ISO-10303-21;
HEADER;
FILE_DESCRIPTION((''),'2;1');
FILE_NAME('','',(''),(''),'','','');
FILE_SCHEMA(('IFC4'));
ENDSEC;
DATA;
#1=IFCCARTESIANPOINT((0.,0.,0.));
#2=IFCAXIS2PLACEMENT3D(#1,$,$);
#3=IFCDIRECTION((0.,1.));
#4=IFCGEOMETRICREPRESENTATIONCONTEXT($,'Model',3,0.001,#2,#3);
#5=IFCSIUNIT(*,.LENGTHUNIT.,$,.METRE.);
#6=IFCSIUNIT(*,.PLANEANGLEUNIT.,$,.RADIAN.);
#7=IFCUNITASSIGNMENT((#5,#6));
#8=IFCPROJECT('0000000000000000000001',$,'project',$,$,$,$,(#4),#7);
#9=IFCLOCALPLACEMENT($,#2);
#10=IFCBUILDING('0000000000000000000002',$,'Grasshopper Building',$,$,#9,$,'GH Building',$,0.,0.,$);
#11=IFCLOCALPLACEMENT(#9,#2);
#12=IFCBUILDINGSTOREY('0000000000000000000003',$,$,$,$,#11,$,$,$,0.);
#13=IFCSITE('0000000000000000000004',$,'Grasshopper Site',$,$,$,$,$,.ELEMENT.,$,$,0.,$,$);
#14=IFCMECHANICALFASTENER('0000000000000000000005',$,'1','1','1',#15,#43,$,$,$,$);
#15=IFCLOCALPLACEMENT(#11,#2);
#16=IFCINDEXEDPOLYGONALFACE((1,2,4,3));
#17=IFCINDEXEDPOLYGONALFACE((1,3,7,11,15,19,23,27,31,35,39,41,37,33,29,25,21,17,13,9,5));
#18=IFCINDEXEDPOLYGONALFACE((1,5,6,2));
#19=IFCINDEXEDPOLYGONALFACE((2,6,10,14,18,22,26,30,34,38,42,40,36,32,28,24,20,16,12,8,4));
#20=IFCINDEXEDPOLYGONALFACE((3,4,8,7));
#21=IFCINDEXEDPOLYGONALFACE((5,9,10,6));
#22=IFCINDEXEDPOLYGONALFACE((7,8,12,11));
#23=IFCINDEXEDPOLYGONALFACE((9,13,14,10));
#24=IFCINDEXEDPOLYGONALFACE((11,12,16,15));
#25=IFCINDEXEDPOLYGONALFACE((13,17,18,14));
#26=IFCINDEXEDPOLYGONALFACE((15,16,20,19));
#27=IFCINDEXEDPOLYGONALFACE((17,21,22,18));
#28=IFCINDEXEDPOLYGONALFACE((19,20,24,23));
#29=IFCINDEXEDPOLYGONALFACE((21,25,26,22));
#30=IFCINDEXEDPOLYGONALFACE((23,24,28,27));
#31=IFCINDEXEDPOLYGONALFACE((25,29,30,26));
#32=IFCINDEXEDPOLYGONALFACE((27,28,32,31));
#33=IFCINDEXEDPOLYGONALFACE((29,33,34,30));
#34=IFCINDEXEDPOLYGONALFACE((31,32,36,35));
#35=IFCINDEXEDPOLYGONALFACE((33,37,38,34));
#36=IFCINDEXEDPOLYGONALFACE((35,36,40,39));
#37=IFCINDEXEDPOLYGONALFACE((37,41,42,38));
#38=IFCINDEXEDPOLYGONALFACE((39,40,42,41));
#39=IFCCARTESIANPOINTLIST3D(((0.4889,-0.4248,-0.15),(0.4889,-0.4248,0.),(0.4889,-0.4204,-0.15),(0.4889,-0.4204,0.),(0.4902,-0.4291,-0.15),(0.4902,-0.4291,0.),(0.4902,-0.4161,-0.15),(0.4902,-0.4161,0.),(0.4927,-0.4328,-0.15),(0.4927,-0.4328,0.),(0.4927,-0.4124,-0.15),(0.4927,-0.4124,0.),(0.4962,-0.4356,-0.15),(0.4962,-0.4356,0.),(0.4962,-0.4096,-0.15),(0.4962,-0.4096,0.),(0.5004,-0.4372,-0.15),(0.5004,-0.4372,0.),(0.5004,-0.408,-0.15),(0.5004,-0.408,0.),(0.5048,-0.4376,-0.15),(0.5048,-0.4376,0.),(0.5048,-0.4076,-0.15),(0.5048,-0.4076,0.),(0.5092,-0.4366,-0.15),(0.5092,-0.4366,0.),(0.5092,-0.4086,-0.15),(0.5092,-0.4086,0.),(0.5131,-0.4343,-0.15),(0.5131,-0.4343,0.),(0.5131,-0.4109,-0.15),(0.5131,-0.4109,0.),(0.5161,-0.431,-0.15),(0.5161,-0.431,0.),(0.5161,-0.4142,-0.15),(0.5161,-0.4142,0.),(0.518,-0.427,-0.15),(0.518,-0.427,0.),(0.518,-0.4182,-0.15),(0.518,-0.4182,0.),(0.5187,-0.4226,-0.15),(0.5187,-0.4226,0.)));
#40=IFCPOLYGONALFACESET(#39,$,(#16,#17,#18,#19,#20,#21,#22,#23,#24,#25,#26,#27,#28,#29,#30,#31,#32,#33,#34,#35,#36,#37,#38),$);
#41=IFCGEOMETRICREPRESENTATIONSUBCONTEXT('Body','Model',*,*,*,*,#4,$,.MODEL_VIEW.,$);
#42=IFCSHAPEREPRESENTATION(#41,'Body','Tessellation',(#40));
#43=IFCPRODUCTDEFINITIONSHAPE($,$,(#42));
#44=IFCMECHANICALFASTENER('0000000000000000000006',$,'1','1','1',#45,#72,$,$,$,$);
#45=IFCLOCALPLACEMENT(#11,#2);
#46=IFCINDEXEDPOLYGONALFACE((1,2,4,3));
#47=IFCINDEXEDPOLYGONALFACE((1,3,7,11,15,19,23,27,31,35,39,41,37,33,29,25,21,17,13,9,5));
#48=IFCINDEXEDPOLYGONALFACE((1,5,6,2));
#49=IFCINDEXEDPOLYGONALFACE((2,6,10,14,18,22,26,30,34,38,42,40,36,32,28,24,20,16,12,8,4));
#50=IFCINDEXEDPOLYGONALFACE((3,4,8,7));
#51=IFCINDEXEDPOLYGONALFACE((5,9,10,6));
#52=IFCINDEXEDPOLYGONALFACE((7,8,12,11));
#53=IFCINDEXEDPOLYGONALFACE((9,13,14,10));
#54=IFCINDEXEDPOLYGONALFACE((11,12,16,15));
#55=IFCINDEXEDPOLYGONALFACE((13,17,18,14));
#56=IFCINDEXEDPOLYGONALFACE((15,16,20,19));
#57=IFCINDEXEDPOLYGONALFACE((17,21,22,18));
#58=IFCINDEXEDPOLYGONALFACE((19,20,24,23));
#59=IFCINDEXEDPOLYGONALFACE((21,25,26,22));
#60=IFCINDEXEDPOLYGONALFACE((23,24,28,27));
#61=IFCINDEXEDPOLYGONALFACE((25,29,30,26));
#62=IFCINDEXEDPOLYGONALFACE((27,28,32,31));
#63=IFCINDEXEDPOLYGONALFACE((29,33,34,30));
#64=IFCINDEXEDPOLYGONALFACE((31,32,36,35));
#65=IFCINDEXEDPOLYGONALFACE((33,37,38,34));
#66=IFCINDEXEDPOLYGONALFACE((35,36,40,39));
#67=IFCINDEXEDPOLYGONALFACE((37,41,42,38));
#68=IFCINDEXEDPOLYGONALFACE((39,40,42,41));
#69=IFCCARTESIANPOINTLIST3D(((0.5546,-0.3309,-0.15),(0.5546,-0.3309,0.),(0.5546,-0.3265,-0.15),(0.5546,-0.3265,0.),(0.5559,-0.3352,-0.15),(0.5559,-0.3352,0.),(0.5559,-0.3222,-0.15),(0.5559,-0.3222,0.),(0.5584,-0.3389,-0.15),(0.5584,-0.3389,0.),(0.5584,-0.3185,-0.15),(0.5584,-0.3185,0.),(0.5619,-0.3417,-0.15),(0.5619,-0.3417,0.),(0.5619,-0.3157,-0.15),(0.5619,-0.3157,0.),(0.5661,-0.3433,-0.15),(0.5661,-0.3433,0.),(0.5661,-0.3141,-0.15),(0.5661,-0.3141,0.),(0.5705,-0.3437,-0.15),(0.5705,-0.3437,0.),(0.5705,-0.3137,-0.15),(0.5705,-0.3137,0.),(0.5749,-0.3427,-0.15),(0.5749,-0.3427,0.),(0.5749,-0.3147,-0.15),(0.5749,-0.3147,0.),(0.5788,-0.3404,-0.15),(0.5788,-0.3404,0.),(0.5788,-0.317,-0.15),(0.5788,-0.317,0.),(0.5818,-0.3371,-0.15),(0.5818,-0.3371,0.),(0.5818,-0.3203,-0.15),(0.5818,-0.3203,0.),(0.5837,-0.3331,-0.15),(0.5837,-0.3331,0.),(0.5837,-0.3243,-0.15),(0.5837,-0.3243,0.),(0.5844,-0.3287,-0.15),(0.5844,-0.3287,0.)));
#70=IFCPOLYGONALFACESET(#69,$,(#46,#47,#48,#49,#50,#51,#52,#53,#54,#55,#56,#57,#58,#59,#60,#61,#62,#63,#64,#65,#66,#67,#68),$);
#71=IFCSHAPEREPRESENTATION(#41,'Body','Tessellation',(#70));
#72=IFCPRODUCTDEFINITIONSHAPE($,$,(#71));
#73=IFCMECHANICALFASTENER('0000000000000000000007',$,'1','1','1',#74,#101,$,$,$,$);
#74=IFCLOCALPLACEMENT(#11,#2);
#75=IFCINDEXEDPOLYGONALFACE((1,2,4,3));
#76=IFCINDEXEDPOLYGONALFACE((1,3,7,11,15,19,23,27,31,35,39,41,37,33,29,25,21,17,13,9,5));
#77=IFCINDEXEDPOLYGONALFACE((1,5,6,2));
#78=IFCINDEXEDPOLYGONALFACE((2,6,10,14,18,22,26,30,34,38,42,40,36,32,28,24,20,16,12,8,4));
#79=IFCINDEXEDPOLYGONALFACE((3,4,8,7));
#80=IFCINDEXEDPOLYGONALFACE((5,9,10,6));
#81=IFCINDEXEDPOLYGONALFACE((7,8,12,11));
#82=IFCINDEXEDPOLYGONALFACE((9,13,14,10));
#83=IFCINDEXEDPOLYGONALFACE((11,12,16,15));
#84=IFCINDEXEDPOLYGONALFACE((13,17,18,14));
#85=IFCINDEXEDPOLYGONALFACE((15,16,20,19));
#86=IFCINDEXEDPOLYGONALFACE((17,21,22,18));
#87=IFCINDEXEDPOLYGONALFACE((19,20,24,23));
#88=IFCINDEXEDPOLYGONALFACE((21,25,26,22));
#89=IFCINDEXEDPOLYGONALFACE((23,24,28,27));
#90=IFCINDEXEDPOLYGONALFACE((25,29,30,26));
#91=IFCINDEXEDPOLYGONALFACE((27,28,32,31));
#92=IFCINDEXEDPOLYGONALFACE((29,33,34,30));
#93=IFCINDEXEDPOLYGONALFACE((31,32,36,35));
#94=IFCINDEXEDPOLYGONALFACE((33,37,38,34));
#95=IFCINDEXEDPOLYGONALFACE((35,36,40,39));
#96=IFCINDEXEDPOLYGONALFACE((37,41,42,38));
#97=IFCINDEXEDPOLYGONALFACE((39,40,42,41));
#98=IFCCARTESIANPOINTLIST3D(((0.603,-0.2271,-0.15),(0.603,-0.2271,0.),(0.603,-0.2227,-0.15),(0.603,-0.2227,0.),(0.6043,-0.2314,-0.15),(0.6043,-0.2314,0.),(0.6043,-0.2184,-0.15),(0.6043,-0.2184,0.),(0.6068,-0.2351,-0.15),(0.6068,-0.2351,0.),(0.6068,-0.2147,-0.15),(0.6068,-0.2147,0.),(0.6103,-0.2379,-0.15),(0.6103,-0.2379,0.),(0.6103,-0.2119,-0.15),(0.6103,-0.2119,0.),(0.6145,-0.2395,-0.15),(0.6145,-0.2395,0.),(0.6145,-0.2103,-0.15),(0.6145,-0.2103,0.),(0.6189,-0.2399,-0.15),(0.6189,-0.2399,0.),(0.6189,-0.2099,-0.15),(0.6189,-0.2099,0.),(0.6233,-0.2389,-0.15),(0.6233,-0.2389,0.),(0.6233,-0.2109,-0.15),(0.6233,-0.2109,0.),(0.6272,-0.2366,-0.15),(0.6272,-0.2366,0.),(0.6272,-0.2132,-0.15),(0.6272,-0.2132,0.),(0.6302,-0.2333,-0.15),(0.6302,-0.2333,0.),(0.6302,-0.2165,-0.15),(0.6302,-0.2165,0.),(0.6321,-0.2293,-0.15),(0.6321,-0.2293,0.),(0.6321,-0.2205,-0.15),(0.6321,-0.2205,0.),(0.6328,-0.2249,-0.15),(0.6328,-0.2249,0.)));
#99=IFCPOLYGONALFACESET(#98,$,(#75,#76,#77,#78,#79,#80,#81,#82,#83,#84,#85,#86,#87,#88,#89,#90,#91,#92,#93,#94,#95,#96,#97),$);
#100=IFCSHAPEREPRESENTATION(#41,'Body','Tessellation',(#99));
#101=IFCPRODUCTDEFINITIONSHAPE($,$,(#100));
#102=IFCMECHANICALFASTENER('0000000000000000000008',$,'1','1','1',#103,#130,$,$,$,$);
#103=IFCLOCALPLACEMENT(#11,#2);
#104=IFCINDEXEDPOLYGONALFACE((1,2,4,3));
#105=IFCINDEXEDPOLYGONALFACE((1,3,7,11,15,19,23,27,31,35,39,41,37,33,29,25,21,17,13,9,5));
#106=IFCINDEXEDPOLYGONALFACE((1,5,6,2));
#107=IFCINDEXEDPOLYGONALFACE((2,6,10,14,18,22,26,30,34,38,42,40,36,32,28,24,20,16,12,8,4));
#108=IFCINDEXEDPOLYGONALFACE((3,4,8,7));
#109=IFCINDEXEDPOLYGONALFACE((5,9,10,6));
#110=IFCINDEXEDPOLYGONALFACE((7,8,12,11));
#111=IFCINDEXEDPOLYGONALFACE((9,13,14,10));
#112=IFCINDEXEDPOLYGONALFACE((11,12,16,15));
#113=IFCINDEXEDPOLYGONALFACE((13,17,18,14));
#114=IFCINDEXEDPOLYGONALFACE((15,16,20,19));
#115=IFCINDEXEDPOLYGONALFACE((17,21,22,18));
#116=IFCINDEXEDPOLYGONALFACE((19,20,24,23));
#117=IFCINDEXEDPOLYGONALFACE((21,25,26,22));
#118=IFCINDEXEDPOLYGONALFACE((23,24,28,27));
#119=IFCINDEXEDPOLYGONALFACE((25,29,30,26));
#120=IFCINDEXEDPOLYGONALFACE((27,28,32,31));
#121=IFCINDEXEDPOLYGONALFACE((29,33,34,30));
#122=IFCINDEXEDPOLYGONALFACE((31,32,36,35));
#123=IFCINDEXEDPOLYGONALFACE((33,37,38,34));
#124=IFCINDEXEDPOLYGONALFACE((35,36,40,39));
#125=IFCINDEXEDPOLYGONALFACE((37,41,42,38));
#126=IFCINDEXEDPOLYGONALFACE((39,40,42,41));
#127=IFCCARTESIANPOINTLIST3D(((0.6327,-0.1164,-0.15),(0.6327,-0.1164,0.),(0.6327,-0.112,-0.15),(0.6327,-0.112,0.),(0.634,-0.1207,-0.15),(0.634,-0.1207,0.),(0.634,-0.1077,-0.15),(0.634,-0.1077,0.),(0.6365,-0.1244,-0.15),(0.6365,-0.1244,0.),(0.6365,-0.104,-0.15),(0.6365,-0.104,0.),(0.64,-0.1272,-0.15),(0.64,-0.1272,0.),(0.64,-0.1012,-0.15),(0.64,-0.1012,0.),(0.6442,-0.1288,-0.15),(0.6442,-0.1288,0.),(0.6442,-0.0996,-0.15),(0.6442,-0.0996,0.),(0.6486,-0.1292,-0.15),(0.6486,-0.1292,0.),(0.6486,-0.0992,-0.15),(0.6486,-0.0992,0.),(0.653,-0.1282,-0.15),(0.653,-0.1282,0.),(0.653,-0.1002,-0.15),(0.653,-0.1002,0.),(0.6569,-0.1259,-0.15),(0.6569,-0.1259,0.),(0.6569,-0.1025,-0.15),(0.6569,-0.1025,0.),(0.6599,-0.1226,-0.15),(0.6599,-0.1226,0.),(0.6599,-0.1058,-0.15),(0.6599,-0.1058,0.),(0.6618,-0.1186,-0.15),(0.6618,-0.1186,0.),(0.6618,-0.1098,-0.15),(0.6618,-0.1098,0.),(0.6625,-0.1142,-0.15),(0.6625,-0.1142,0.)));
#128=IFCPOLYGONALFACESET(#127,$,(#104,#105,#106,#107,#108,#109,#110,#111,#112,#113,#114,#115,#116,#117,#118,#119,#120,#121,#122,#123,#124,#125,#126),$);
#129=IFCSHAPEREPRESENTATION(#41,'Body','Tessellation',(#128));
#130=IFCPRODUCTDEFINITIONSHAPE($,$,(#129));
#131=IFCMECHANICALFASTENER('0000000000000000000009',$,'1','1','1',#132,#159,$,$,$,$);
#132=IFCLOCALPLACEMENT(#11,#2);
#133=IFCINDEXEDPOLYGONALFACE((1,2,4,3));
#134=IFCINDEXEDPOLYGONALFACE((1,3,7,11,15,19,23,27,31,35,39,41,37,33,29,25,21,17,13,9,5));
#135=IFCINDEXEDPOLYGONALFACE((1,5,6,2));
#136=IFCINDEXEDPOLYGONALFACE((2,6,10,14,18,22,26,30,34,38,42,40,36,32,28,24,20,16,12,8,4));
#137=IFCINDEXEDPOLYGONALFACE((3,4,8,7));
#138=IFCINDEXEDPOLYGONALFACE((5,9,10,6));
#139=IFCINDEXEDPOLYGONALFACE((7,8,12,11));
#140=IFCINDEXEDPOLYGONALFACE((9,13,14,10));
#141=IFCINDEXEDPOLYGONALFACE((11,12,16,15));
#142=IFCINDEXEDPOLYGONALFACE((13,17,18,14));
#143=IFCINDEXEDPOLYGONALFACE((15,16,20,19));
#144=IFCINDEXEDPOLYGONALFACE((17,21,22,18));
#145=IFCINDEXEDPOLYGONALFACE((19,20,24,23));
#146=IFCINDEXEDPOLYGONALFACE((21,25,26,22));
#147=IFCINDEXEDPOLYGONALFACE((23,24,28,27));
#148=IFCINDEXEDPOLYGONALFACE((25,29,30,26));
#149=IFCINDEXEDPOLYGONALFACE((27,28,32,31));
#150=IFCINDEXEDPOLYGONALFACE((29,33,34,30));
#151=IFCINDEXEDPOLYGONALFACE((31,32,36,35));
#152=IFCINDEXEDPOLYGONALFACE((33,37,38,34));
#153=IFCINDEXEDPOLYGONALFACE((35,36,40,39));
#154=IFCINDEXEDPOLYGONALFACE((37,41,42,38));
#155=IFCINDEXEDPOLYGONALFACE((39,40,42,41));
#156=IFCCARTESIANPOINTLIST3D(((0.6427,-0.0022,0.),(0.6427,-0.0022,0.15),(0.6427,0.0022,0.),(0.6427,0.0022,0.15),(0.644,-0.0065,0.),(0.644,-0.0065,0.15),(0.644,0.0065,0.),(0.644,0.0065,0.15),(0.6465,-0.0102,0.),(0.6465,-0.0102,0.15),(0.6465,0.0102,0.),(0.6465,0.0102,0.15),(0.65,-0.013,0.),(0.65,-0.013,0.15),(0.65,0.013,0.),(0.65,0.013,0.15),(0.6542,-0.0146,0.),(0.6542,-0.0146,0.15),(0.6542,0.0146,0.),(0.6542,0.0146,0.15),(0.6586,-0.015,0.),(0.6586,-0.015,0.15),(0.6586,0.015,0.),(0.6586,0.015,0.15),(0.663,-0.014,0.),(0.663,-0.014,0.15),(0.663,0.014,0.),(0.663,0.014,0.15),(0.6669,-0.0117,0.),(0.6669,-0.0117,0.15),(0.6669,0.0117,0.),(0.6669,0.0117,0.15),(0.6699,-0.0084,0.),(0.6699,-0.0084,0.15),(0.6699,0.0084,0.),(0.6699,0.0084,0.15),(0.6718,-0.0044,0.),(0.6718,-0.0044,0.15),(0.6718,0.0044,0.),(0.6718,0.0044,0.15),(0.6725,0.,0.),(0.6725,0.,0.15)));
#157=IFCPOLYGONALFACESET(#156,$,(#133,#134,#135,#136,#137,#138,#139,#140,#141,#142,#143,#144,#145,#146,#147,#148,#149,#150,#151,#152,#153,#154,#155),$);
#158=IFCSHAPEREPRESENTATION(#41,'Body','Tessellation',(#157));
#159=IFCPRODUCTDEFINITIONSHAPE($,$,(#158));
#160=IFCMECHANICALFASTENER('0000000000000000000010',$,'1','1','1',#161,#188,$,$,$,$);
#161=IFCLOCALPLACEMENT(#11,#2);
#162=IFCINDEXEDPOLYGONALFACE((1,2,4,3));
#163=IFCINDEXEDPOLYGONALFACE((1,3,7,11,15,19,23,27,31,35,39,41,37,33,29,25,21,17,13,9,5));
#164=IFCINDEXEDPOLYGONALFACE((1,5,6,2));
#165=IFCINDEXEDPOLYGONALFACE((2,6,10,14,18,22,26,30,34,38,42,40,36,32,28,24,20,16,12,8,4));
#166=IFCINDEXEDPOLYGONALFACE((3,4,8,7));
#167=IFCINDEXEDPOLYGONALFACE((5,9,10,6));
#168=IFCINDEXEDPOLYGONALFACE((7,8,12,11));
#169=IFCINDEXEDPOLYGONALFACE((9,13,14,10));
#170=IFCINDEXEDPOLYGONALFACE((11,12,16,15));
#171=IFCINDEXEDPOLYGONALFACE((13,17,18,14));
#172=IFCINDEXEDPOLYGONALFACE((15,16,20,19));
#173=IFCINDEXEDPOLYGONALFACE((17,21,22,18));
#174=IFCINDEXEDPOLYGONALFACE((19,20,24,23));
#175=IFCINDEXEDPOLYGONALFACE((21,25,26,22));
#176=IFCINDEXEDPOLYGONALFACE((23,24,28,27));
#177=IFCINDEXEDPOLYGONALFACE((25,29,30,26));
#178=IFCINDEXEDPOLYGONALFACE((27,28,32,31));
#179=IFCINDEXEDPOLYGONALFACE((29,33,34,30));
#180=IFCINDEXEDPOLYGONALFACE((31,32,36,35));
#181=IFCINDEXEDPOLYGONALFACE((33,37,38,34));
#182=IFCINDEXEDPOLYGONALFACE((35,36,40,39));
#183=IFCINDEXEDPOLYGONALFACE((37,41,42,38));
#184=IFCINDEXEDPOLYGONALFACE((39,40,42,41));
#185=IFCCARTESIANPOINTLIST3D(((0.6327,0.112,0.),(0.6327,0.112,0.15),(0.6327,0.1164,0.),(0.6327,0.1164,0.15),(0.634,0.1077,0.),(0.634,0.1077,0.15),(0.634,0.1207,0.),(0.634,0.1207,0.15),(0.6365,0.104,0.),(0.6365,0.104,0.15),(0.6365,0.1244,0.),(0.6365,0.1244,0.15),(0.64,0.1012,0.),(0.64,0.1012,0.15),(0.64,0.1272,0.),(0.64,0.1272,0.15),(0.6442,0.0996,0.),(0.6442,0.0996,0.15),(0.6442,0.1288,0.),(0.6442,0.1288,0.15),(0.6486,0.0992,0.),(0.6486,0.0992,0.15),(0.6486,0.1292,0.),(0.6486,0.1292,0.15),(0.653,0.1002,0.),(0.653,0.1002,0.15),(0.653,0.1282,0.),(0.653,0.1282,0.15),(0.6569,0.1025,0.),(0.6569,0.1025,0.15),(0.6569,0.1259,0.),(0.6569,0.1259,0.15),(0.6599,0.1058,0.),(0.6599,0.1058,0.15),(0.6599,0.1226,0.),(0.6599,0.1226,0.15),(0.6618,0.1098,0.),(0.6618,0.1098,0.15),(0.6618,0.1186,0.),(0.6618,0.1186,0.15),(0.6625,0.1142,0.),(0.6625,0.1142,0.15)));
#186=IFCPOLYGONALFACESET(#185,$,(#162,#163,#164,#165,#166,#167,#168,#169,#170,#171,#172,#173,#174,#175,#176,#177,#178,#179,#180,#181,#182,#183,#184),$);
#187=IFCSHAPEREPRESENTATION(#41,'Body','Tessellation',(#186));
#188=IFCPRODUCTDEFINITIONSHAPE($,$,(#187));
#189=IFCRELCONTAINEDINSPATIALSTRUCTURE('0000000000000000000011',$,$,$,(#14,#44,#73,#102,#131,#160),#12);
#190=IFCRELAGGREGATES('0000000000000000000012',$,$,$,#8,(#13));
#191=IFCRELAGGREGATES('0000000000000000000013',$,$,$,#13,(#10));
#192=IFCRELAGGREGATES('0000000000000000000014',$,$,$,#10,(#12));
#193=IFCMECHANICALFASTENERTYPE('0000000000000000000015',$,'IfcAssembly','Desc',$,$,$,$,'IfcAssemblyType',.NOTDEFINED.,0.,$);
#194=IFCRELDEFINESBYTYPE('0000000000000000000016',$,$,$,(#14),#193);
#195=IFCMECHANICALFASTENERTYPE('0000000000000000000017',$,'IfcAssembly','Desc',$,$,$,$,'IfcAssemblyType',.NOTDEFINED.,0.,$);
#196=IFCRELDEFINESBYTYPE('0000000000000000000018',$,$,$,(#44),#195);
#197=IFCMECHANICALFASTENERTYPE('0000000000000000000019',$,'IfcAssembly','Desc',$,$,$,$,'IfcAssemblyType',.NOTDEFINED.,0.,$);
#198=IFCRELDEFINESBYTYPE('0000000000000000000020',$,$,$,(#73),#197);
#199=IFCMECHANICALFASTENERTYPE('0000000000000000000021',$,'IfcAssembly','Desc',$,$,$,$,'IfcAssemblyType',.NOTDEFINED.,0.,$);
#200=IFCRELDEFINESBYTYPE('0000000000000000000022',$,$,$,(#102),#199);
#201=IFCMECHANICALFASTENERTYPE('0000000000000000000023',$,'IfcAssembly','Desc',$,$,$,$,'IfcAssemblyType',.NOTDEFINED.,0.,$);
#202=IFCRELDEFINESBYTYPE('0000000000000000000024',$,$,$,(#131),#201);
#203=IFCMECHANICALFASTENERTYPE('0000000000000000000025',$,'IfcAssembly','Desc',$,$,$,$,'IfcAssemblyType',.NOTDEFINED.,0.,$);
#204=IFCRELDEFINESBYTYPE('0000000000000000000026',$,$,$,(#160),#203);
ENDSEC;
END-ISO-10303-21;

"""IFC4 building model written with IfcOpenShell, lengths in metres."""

from ifc_helpers import new_model, si_unit, direction, frame, origin, place, context, subcontext, project, spatial, circle, extrude, source, transform, mapped, type_object, type_shapes, element, save


model = new_model("IFC4")

# Units and contexts
model_context = context("Model", 3, precision=0.001, world=origin(), true_north=direction((0.0, 1.0)))
body_context = subcontext(model_context, "Body", "Model", "MODEL_VIEW")
ifc_project = project(units=[si_unit("LENGTHUNIT", "METRE"), si_unit("PLANEANGLEUNIT", "RADIAN")], contexts=[model_context])

# Site, building, storey
site = spatial("IfcSite", under=ifc_project, Name="Grasshopper Site", CompositionType="ELEMENT", RefElevation=0.0)
building_placement = place(None, origin())
building = spatial("IfcBuilding", under=site, at=building_placement, Name="Grasshopper Building", LongName="GH Building", ElevationOfRefHeight=0.0, ElevationOfTerrain=0.0)
storey_placement = place(building_placement, origin())
storey = spatial("IfcBuildingStorey", under=building, at=storey_placement, Elevation=0.0)

# Mechanical fasteners
mechanical_fastener_type_1 = type_object("IfcMechanicalFastenerType", Name="IfcAssembly", Description="Desc", ElementType="IfcAssemblyType", NominalDiameter=0.0)
shared_shape_1 = source(origin(), body_context, "Body", "SweptSolid", [
    extrude(circle(Radius=0.015), frame((0.5037, -0.4226, 0.0), z_axis=(0.0, 0.0, -1.0), x_axis=(1.0, 0.0, 0.0)), (0.0, 0.0, 1.0), 0.15),
])
type_shapes(mechanical_fastener_type_1, [shared_shape_1])
mechanical_fastener_1_placement = place(storey_placement, origin())
element("IfcMechanicalFastener", 1, at=mechanical_fastener_1_placement, inside=storey, type_object=mechanical_fastener_type_1, Name="1", Description="1", ObjectType="1", context=body_context, shape_type="MappedRepresentation", body=[
    mapped(shared_shape_1, transform((0.0, 0.0, 0.0), scale=1.0)),
])
mechanical_fastener_type_2 = type_object("IfcMechanicalFastenerType", Name="IfcAssembly", Description="Desc", ElementType="IfcAssemblyType", NominalDiameter=0.0)
shared_shape_2 = source(origin(), body_context, "Body", "SweptSolid", [
    extrude(circle(Radius=0.015), frame((0.5694, -0.3287, 0.0), z_axis=(0.0, 0.0, -1.0), x_axis=(1.0, 0.0, 0.0)), (0.0, 0.0, 1.0), 0.15),
])
type_shapes(mechanical_fastener_type_2, [shared_shape_2])
mechanical_fastener_2_placement = place(storey_placement, origin())
element("IfcMechanicalFastener", 2, at=mechanical_fastener_2_placement, inside=storey, type_object=mechanical_fastener_type_2, Name="1", Description="1", ObjectType="1", context=body_context, shape_type="MappedRepresentation", body=[
    mapped(shared_shape_2, transform((0.0, 0.0, 0.0), scale=1.0)),
])
mechanical_fastener_type_3 = type_object("IfcMechanicalFastenerType", Name="IfcAssembly", Description="Desc", ElementType="IfcAssemblyType", NominalDiameter=0.0)
shared_shape_3 = source(origin(), body_context, "Body", "SweptSolid", [
    extrude(circle(Radius=0.015), frame((0.6178, -0.2249, 0.0), z_axis=(0.0, 0.0, -1.0), x_axis=(1.0, 0.0, 0.0)), (0.0, 0.0, 1.0), 0.15),
])
type_shapes(mechanical_fastener_type_3, [shared_shape_3])
mechanical_fastener_3_placement = place(storey_placement, origin())
element("IfcMechanicalFastener", 3, at=mechanical_fastener_3_placement, inside=storey, type_object=mechanical_fastener_type_3, Name="1", Description="1", ObjectType="1", context=body_context, shape_type="MappedRepresentation", body=[
    mapped(shared_shape_3, transform((0.0, 0.0, 0.0), scale=1.0)),
])
mechanical_fastener_type_4 = type_object("IfcMechanicalFastenerType", Name="IfcAssembly", Description="Desc", ElementType="IfcAssemblyType", NominalDiameter=0.0)
shared_shape_4 = source(origin(), body_context, "Body", "SweptSolid", [
    extrude(circle(Radius=0.015), frame((0.6475, -0.1142, 0.0), z_axis=(0.0, 0.0, -1.0), x_axis=(1.0, 0.0, 0.0)), (0.0, 0.0, 1.0), 0.15),
])
type_shapes(mechanical_fastener_type_4, [shared_shape_4])
mechanical_fastener_4_placement = place(storey_placement, origin())
element("IfcMechanicalFastener", 4, at=mechanical_fastener_4_placement, inside=storey, type_object=mechanical_fastener_type_4, Name="1", Description="1", ObjectType="1", context=body_context, shape_type="MappedRepresentation", body=[
    mapped(shared_shape_4, transform((0.0, 0.0, 0.0), scale=1.0)),
])
mechanical_fastener_type_5 = type_object("IfcMechanicalFastenerType", Name="IfcAssembly", Description="Desc", ElementType="IfcAssemblyType", NominalDiameter=0.0)
shared_shape_5 = source(origin(), body_context, "Body", "SweptSolid", [
    extrude(circle(Radius=0.015), frame((0.6575, 0.0, 0.0)), (0.0, 0.0, 1.0), 0.15),
])
type_shapes(mechanical_fastener_type_5, [shared_shape_5])
mechanical_fastener_5_placement = place(storey_placement, origin())
element("IfcMechanicalFastener", 5, at=mechanical_fastener_5_placement, inside=storey, type_object=mechanical_fastener_type_5, Name="1", Description="1", ObjectType="1", context=body_context, shape_type="MappedRepresentation", body=[
    mapped(shared_shape_5, transform((0.0, 0.0, 0.0), scale=1.0)),
])
mechanical_fastener_type_6 = type_object("IfcMechanicalFastenerType", Name="IfcAssembly", Description="Desc", ElementType="IfcAssemblyType", NominalDiameter=0.0)
shared_shape_6 = source(origin(), body_context, "Body", "SweptSolid", [
    extrude(circle(Radius=0.015), frame((0.6475, 0.1142, 0.0)), (0.0, 0.0, 1.0), 0.15),
])
type_shapes(mechanical_fastener_type_6, [shared_shape_6])
mechanical_fastener_6_placement = place(storey_placement, origin())
element("IfcMechanicalFastener", 6, at=mechanical_fastener_6_placement, inside=storey, type_object=mechanical_fastener_type_6, Name="1", Description="1", ObjectType="1", context=body_context, shape_type="MappedRepresentation", body=[
    mapped(shared_shape_6, transform((0.0, 0.0, 0.0), scale=1.0)),
])

save(model, "model.ifc")
